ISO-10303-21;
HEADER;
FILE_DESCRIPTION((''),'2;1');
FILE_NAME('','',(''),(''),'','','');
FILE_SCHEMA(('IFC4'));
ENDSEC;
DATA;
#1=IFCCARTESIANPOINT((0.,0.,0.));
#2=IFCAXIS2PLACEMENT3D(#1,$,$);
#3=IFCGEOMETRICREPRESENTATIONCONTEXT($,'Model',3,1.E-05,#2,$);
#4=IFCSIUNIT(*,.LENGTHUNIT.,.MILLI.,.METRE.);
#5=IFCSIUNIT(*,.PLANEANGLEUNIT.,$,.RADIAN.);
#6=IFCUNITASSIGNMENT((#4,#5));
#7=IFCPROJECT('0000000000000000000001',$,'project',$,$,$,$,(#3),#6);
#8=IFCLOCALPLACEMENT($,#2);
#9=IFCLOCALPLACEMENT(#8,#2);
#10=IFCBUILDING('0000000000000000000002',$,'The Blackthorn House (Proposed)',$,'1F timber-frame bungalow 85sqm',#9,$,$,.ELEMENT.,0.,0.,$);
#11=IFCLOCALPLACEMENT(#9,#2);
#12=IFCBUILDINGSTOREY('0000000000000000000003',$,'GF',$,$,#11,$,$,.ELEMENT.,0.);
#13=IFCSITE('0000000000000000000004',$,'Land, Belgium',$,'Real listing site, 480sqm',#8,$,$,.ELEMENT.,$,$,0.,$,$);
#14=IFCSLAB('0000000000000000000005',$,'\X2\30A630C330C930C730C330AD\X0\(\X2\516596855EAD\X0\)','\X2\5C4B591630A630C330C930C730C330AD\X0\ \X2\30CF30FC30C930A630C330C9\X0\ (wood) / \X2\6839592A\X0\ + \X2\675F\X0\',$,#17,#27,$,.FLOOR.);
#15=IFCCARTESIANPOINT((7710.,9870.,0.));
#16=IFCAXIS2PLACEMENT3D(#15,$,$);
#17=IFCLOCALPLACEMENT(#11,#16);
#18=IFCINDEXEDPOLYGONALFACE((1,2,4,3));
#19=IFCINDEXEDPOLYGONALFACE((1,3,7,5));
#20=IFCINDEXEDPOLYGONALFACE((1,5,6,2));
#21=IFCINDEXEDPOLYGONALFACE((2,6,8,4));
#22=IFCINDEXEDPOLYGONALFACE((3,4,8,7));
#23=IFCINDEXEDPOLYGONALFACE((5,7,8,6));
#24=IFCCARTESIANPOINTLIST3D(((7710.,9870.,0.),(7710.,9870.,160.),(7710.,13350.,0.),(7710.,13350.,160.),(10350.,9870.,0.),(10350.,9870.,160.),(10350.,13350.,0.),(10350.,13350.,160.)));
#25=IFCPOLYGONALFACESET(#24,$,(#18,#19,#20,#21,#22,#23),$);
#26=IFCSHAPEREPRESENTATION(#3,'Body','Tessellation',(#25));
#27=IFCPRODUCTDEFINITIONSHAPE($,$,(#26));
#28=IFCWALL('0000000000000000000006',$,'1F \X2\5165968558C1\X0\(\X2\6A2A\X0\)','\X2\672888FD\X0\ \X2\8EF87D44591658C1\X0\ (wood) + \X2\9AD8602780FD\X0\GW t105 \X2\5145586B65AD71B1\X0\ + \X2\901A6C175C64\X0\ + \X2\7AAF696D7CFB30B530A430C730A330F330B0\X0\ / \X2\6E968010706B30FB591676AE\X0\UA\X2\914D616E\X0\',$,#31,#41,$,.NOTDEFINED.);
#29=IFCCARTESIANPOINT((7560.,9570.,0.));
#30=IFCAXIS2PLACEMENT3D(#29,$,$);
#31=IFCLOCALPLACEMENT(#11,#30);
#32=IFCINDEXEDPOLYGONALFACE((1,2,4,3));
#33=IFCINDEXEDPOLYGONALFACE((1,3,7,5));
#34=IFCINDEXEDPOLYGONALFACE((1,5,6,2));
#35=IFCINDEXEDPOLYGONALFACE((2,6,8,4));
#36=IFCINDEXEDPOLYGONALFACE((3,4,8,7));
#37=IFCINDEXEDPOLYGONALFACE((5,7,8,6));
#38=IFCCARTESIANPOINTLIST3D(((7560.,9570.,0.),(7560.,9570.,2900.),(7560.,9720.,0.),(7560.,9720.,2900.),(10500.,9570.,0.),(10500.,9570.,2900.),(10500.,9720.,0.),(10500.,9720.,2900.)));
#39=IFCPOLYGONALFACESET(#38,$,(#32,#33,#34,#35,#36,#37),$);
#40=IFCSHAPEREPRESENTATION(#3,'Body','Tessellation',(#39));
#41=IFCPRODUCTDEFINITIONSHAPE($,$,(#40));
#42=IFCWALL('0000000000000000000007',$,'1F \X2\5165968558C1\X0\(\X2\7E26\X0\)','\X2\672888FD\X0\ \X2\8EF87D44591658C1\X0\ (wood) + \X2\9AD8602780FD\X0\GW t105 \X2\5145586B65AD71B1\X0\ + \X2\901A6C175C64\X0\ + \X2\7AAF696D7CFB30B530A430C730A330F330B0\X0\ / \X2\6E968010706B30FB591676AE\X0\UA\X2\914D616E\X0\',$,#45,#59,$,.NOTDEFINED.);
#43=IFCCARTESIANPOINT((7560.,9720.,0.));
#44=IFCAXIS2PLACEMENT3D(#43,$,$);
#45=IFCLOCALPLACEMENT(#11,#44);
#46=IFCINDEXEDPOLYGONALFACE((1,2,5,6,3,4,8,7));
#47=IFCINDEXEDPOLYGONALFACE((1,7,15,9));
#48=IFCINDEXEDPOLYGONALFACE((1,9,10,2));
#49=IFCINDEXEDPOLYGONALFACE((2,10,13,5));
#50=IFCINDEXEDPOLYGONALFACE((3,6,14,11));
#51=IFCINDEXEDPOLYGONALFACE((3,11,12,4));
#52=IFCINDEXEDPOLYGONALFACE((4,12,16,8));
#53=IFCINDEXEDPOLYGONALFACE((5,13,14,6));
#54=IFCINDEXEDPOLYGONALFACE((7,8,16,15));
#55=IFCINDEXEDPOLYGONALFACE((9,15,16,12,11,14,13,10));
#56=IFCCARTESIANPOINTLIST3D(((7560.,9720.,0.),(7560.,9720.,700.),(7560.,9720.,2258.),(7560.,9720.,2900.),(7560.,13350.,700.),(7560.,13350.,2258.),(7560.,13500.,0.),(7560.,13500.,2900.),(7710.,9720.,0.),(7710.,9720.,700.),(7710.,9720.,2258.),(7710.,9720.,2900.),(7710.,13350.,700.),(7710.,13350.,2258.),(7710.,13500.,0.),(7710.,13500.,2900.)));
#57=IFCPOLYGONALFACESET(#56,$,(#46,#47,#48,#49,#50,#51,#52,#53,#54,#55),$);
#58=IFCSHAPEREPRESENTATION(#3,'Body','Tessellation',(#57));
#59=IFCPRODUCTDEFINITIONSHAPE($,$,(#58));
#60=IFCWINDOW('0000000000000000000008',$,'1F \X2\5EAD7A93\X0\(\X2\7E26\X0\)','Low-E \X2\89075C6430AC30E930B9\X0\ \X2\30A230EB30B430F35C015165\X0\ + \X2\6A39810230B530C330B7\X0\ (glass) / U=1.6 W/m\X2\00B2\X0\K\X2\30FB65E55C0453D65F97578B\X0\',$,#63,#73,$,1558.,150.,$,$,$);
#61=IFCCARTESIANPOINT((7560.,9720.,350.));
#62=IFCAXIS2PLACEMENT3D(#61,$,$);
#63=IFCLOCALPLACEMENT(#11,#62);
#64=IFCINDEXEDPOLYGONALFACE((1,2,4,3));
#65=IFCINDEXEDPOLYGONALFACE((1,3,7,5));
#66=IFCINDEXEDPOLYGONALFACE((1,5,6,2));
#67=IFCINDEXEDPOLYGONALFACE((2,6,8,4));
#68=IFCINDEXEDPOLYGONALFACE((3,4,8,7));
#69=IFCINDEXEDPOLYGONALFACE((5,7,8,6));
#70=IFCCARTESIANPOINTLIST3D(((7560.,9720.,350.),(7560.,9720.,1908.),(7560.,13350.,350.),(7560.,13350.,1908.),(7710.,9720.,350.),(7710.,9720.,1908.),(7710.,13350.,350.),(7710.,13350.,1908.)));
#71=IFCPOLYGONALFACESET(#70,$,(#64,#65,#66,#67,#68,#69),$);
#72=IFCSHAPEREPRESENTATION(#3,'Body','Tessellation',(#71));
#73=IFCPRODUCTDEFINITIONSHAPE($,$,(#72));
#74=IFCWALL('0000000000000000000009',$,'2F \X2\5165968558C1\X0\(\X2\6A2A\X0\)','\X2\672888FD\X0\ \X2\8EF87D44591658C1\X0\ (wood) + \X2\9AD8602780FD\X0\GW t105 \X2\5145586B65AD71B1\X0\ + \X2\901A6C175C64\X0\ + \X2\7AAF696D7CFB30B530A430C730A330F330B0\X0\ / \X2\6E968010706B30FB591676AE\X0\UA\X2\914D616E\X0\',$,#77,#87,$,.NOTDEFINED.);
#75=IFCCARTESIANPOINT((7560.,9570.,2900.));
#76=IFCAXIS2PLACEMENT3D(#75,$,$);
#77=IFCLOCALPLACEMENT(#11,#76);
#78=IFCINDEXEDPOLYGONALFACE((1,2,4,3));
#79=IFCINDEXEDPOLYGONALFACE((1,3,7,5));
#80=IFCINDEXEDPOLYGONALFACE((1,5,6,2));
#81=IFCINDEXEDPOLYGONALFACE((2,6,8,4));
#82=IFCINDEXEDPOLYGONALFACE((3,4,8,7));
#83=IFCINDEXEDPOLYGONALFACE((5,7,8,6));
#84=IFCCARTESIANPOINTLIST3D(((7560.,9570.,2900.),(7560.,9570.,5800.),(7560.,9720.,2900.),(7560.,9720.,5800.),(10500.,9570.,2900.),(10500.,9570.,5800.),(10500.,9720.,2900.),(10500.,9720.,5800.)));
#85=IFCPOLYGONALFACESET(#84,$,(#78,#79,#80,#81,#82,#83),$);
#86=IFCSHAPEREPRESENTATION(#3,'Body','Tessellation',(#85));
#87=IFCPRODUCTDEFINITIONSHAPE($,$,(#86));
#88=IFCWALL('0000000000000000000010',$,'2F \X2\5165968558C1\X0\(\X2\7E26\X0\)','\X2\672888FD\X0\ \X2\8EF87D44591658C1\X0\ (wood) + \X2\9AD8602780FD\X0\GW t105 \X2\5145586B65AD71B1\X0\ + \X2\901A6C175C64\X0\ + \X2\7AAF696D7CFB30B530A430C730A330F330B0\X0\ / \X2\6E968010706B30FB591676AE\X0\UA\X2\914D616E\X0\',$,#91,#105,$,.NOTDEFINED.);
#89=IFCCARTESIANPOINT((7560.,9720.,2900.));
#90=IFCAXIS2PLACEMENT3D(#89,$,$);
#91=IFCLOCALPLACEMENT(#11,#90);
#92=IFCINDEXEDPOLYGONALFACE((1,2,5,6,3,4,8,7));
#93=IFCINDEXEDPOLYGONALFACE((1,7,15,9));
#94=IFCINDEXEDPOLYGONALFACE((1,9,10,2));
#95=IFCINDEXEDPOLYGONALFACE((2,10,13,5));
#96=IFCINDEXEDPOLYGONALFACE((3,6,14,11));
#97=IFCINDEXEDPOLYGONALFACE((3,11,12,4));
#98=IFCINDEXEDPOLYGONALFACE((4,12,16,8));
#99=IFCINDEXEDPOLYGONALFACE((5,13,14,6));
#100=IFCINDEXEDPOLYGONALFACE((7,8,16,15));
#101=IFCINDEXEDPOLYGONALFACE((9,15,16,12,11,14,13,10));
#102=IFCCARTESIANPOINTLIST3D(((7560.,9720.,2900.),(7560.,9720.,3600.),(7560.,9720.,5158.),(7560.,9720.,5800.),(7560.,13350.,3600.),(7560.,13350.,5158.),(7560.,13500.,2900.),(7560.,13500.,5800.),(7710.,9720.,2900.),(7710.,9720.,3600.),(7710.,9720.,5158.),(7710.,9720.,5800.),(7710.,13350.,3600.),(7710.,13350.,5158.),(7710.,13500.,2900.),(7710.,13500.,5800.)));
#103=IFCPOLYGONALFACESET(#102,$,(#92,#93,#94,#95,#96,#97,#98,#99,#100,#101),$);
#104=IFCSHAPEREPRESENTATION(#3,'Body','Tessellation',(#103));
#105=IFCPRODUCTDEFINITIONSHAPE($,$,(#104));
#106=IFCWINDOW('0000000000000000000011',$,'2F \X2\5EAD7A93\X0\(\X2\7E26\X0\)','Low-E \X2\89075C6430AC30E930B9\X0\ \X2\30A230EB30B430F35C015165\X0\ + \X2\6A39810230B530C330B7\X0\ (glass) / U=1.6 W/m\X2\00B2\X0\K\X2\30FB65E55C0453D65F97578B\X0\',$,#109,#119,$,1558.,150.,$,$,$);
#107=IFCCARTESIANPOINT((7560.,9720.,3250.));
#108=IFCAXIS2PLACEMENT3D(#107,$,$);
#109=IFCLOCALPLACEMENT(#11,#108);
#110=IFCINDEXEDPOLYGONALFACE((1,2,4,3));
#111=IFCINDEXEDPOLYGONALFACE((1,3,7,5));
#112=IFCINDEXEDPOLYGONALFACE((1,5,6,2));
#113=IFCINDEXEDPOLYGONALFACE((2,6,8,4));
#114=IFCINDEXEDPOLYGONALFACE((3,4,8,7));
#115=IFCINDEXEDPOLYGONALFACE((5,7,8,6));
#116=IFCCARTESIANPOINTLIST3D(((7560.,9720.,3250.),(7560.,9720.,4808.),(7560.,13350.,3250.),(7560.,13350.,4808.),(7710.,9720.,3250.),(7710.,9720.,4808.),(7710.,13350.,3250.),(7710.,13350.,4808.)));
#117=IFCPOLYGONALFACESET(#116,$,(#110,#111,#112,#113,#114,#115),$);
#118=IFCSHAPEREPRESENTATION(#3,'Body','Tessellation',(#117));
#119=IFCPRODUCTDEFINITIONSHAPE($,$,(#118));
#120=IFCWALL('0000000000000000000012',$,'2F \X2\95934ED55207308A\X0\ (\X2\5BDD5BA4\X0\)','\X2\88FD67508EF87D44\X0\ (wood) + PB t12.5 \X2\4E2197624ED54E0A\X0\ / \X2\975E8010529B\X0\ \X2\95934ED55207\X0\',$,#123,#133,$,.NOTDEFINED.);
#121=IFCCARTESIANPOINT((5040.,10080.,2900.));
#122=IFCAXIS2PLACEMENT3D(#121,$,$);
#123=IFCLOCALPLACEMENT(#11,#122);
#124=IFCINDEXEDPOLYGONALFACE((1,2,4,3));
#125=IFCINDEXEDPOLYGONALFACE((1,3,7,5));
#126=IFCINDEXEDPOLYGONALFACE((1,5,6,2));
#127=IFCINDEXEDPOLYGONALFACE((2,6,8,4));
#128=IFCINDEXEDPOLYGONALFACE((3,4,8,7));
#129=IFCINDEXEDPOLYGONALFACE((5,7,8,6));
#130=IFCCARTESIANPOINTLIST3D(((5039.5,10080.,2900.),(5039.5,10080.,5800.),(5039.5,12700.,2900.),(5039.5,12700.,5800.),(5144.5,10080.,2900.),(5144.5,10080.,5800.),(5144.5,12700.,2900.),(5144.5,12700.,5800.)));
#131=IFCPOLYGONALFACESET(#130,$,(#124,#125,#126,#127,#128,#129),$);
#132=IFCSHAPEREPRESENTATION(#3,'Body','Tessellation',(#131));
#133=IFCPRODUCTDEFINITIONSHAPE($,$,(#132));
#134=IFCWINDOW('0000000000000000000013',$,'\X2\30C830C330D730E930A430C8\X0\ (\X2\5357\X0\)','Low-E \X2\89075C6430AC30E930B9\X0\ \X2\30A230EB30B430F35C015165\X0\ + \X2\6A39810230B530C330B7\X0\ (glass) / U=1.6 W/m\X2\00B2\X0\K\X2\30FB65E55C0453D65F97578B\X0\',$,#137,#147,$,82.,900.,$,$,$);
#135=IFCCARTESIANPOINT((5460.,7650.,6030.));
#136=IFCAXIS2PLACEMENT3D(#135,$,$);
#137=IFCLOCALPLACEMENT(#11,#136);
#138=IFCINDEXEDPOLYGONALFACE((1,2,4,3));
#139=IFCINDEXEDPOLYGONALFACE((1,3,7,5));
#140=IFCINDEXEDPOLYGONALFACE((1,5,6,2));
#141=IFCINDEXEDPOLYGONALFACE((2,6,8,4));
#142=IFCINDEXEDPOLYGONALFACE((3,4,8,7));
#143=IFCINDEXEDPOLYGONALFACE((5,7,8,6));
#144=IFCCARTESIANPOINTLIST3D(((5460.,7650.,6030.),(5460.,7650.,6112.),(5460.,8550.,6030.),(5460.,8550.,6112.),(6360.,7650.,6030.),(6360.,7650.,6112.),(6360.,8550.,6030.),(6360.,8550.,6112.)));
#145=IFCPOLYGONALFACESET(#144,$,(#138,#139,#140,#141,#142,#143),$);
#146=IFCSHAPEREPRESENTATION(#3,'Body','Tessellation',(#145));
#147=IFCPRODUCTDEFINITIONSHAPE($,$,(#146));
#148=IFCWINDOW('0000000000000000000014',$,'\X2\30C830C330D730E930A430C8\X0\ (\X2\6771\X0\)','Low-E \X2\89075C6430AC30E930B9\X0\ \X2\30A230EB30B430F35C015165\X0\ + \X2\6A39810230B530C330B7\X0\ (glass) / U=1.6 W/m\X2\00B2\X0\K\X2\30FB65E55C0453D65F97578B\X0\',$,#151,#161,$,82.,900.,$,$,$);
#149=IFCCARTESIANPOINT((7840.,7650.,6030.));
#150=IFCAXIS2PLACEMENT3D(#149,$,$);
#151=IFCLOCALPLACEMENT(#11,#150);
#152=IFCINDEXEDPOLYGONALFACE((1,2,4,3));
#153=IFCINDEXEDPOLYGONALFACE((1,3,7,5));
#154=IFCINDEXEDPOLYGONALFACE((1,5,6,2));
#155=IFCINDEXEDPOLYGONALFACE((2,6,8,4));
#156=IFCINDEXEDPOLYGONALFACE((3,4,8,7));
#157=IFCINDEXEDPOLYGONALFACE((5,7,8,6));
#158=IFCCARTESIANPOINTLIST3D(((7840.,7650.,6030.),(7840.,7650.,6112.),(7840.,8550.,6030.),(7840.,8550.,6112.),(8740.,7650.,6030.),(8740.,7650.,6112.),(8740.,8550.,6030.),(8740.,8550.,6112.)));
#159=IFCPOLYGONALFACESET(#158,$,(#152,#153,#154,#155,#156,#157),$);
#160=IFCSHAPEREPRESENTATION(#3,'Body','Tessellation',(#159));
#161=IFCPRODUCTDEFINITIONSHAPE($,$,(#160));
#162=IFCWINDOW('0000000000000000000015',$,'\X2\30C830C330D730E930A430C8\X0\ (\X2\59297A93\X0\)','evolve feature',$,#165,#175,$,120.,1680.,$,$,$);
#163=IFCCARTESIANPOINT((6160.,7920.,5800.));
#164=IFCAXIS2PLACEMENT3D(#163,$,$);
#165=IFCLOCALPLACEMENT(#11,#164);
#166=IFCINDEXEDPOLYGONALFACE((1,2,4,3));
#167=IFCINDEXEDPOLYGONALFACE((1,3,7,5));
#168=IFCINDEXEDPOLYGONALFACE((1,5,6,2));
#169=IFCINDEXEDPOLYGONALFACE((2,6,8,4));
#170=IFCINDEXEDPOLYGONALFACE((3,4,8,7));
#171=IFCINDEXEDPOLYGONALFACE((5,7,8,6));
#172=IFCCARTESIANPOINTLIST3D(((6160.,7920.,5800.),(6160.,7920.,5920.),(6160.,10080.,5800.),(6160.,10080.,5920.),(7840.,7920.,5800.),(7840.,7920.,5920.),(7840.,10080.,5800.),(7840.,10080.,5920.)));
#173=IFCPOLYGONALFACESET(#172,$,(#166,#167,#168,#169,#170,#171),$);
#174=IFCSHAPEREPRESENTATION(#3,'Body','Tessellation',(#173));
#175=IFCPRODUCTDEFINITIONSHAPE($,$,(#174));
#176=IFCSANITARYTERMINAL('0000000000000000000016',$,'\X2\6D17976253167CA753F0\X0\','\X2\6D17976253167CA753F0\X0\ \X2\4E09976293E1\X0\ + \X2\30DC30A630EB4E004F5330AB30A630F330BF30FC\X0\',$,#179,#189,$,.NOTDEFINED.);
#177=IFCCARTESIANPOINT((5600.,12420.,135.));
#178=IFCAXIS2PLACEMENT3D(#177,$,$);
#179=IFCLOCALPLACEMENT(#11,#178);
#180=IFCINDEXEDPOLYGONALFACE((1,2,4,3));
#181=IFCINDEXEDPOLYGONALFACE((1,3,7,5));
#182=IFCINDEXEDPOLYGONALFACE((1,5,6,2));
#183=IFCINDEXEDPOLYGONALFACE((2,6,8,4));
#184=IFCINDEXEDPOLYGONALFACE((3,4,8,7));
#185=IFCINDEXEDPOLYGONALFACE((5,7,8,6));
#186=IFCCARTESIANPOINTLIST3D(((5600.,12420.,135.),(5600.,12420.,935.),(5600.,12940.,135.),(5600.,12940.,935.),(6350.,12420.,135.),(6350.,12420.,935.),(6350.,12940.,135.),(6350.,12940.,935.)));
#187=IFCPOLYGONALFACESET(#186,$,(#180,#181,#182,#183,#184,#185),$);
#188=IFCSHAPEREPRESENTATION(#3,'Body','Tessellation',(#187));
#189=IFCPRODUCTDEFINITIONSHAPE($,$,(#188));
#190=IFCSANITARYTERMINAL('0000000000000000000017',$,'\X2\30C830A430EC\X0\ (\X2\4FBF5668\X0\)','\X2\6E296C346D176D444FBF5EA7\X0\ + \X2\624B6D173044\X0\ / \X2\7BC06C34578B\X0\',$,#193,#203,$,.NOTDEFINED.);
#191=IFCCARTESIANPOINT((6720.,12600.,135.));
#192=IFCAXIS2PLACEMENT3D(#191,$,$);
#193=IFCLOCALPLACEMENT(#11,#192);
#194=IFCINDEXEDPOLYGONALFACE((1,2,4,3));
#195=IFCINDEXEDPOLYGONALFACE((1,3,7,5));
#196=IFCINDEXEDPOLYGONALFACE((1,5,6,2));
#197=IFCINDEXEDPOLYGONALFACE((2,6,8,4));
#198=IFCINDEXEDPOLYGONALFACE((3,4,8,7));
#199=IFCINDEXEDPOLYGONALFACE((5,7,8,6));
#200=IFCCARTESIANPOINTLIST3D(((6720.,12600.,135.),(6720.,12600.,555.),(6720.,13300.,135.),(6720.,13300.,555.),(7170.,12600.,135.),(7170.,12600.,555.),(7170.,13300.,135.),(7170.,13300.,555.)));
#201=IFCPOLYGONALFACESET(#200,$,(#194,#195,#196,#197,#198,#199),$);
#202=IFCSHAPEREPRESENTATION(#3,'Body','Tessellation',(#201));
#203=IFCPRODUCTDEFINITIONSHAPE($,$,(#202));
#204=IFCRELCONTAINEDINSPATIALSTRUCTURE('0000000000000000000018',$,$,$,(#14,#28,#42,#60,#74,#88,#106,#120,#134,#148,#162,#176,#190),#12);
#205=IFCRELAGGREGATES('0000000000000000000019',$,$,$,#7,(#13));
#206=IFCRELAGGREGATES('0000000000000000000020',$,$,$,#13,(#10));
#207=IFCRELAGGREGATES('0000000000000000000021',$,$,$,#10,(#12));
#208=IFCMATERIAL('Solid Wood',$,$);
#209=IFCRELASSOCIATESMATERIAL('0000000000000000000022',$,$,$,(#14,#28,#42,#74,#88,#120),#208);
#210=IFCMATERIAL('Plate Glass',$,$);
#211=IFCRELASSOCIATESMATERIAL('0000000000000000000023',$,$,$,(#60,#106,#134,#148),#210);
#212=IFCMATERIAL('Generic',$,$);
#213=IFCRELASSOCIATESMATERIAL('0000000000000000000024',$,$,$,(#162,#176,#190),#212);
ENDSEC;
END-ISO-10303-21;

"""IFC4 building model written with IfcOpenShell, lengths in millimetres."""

from ifc_helpers import new_model, si_unit, frame, frame_2d, origin, place, context, project, spatial, rectangle, extrude, material, element, fill, save


model = new_model("IFC4")

# Units and contexts
model_context = context("Model", 3, precision=1e-05, world=origin())
ifc_project = project(units=[si_unit("LENGTHUNIT", "METRE", prefix="MILLI"), si_unit("PLANEANGLEUNIT", "RADIAN")], contexts=[model_context])

# Site, building, storey
site_placement = place(None, origin())
site = spatial("IfcSite", under=ifc_project, at=site_placement, Name="Land, Belgium", ObjectType="Real listing site, 480sqm", CompositionType="ELEMENT", RefElevation=0.0)
building_placement = place(site_placement, origin())
building = spatial("IfcBuilding", under=site, at=building_placement, Name="The Blackthorn House (Proposed)", ObjectType="1F timber-frame bungalow 85sqm", CompositionType="ELEMENT", ElevationOfRefHeight=0.0, ElevationOfTerrain=0.0)
storey_placement = place(building_placement, origin())
storey = spatial("IfcBuildingStorey", under=building, at=storey_placement, Name="GF", CompositionType="ELEMENT", Elevation=0.0)

# Slab
ifc_material_1 = material(Name="Solid Wood")
slab_placement = place(storey_placement, frame((7710.0, 9870.0, 0.0)))
element("IfcSlab", 1, at=slab_placement, inside=storey, material=ifc_material_1, Name="ウッドデッキ(入隅庭)", Description="屋外ウッドデッキ ハードウッド (wood) / 根太 + 束", PredefinedType="FLOOR", context=model_context, shape_type="SweptSolid", body=[
    extrude(rectangle(XDim=2640.0, YDim=3480.0, at=frame_2d((1320.0, 1740.0))), frame((7710.0, 9870.0, 0.0)), (0.0, 0.0, 1.0), 160.0),
])

# Wall
wall_1_placement = place(storey_placement, frame((7560.0, 9570.0, 0.0)))
element("IfcWall", 2, at=wall_1_placement, inside=storey, material=ifc_material_1, Name="1F 入隅壁(横)", Description="木製 軸組外壁 (wood) + 高性能GW t105 充填断熱 + 通気層 + 窯業系サイディング / 準耐火・外皮UA配慮", PredefinedType="NOTDEFINED", context=model_context, shape_type="SweptSolid", body=[
    extrude(rectangle(XDim=2940.0, YDim=150.0, at=frame_2d((1470.0, 75.0))), frame((7560.0, 9570.0, 0.0)), (0.0, 0.0, 1.0), 2900.0),
])

# Wall, opening, window
wall_2_placement = place(storey_placement, frame((7560.0, 9720.0, 0.0)))
wall_2 = element("IfcWall", 3, at=wall_2_placement, inside=storey, material=ifc_material_1, Name="1F 入隅壁(縦)", Description="木製 軸組外壁 (wood) + 高性能GW t105 充填断熱 + 通気層 + 窯業系サイディング / 準耐火・外皮UA配慮", PredefinedType="NOTDEFINED", context=model_context, shape_type="SweptSolid", body=[
    extrude(rectangle(XDim=150.0, YDim=3780.0, at=frame_2d((75.0, 1890.0))), frame((7560.0, 9720.0, 0.0)), (0.0, 0.0, 1.0), 2900.0),
])
opening_1_placement = place(storey_placement, frame((7560.0, 9720.0, 350.0)))
opening_1 = element("IfcOpeningElement", 4, at=opening_1_placement, cuts=wall_2, PredefinedType="NOTDEFINED", context=model_context, shape_type="SweptSolid", body=[
    extrude(rectangle(XDim=150.0, YDim=3630.0, at=frame_2d((75.0, 1815.0))), frame((7560.0, 9720.0, 350.0)), (0.0, 0.0, 1.0), 1558.0),
])
ifc_material_2 = material(Name="Plate Glass")
window_1_placement = place(storey_placement, frame((7560.0, 9720.0, 350.0)))
window_1 = element("IfcWindow", 5, at=window_1_placement, inside=storey, material=ifc_material_2, Name="1F 庭窓(縦)", Description="Low-E 複層ガラス アルゴン封入 + 樹脂サッシ (glass) / U=1.6 W/m²K・日射取得型", OverallHeight=1558.0, OverallWidth=150.0, context=model_context, shape_type="SweptSolid", body=[
    extrude(rectangle(XDim=150.0, YDim=3630.0, at=frame_2d((75.0, 1815.0))), frame((7560.0, 9720.0, 350.0)), (0.0, 0.0, 1.0), 1558.0),
])
fill(opening_1, window_1)

# Wall
wall_3_placement = place(storey_placement, frame((7560.0, 9570.0, 2900.0)))
element("IfcWall", 6, at=wall_3_placement, inside=storey, material=ifc_material_1, Name="2F 入隅壁(横)", Description="木製 軸組外壁 (wood) + 高性能GW t105 充填断熱 + 通気層 + 窯業系サイディング / 準耐火・外皮UA配慮", PredefinedType="NOTDEFINED", context=model_context, shape_type="SweptSolid", body=[
    extrude(rectangle(XDim=2940.0, YDim=150.0, at=frame_2d((1470.0, 75.0))), frame((7560.0, 9570.0, 2900.0)), (0.0, 0.0, 1.0), 2900.0),
])

# Wall, opening, window
wall_4_placement = place(storey_placement, frame((7560.0, 9720.0, 2900.0)))
wall_4 = element("IfcWall", 7, at=wall_4_placement, inside=storey, material=ifc_material_1, Name="2F 入隅壁(縦)", Description="木製 軸組外壁 (wood) + 高性能GW t105 充填断熱 + 通気層 + 窯業系サイディング / 準耐火・外皮UA配慮", PredefinedType="NOTDEFINED", context=model_context, shape_type="SweptSolid", body=[
    extrude(rectangle(XDim=150.0, YDim=3780.0, at=frame_2d((75.0, 1890.0))), frame((7560.0, 9720.0, 2900.0)), (0.0, 0.0, 1.0), 2900.0),
])
opening_2_placement = place(storey_placement, frame((7560.0, 9720.0, 3250.0)))
opening_2 = element("IfcOpeningElement", 8, at=opening_2_placement, cuts=wall_4, PredefinedType="NOTDEFINED", context=model_context, shape_type="SweptSolid", body=[
    extrude(rectangle(XDim=150.0, YDim=3630.0, at=frame_2d((75.0, 1815.0))), frame((7560.0, 9720.0, 3250.0)), (0.0, 0.0, 1.0), 1558.0),
])
window_2_placement = place(storey_placement, frame((7560.0, 9720.0, 3250.0)))
window_2 = element("IfcWindow", 9, at=window_2_placement, inside=storey, material=ifc_material_2, Name="2F 庭窓(縦)", Description="Low-E 複層ガラス アルゴン封入 + 樹脂サッシ (glass) / U=1.6 W/m²K・日射取得型", OverallHeight=1558.0, OverallWidth=150.0, context=model_context, shape_type="SweptSolid", body=[
    extrude(rectangle(XDim=150.0, YDim=3630.0, at=frame_2d((75.0, 1815.0))), frame((7560.0, 9720.0, 3250.0)), (0.0, 0.0, 1.0), 1558.0),
])
fill(opening_2, window_2)

# Wall
wall_5_placement = place(storey_placement, frame((5040.0, 10080.0, 2900.0)))
element("IfcWall", 10, at=wall_5_placement, inside=storey, material=ifc_material_1, Name="2F 間仕切り (寝室)", Description="製材軸組 (wood) + PB t12.5 両面仕上 / 非耐力 間仕切", PredefinedType="NOTDEFINED", context=model_context, shape_type="SweptSolid", body=[
    extrude(rectangle(XDim=105.0, YDim=2620.0, at=frame_2d((52.0, 1310.0))), frame((5040.0, 10080.0, 2900.0)), (0.0, 0.0, 1.0), 2900.0),
])

# Windows
window_3_placement = place(storey_placement, frame((5460.0, 7650.0, 6030.0)))
element("IfcWindow", 11, at=window_3_placement, inside=storey, material=ifc_material_2, Name="トップライト (南)", Description="Low-E 複層ガラス アルゴン封入 + 樹脂サッシ (glass) / U=1.6 W/m²K・日射取得型", OverallHeight=82.0, OverallWidth=900.0, context=model_context, shape_type="SweptSolid", body=[
    extrude(rectangle(XDim=900.0, YDim=900.0, at=frame_2d((450.0, 450.0))), frame((5460.0, 7650.0, 6030.0)), (0.0, 0.0, 1.0), 82.0),
])
window_4_placement = place(storey_placement, frame((7840.0, 7650.0, 6030.0)))
element("IfcWindow", 12, at=window_4_placement, inside=storey, material=ifc_material_2, Name="トップライト (東)", Description="Low-E 複層ガラス アルゴン封入 + 樹脂サッシ (glass) / U=1.6 W/m²K・日射取得型", OverallHeight=82.0, OverallWidth=900.0, context=model_context, shape_type="SweptSolid", body=[
    extrude(rectangle(XDim=900.0, YDim=900.0, at=frame_2d((450.0, 450.0))), frame((7840.0, 7650.0, 6030.0)), (0.0, 0.0, 1.0), 82.0),
])
ifc_material_3 = material(Name="Generic")
window_5_placement = place(storey_placement, frame((6160.0, 7920.0, 5800.0)))
element("IfcWindow", 13, at=window_5_placement, inside=storey, material=ifc_material_3, Name="トップライト (天窓)", Description="evolve feature", OverallHeight=120.0, OverallWidth=1680.0, context=model_context, shape_type="SweptSolid", body=[
    extrude(rectangle(XDim=1680.0, YDim=2160.0, at=frame_2d((840.0, 1080.0))), frame((6160.0, 7920.0, 5800.0)), (0.0, 0.0, 1.0), 120.0),
])

# Sanitary terminals
sanitary_terminal_1_placement = place(storey_placement, frame((5600.0, 12420.0, 135.0)))
element("IfcSanitaryTerminal", 14, at=sanitary_terminal_1_placement, inside=storey, material=ifc_material_3, Name="洗面化粧台", Description="洗面化粧台 三面鏡 + ボウル一体カウンター", PredefinedType="NOTDEFINED", context=model_context, shape_type="SweptSolid", body=[
    extrude(rectangle(XDim=750.0, YDim=520.0, at=frame_2d((375.0, 260.0))), frame((5600.0, 12420.0, 135.0)), (0.0, 0.0, 1.0), 800.0),
])
sanitary_terminal_2_placement = place(storey_placement, frame((6720.0, 12600.0, 135.0)))
element("IfcSanitaryTerminal", 15, at=sanitary_terminal_2_placement, inside=storey, material=ifc_material_3, Name="トイレ (便器)", Description="温水洗浄便座 + 手洗い / 節水型", PredefinedType="NOTDEFINED", context=model_context, shape_type="SweptSolid", body=[
    extrude(rectangle(XDim=450.0, YDim=700.0, at=frame_2d((225.0, 350.0))), frame((6720.0, 12600.0, 135.0)), (0.0, 0.0, 1.0), 420.0),
])

save(model, "model.ifc")
